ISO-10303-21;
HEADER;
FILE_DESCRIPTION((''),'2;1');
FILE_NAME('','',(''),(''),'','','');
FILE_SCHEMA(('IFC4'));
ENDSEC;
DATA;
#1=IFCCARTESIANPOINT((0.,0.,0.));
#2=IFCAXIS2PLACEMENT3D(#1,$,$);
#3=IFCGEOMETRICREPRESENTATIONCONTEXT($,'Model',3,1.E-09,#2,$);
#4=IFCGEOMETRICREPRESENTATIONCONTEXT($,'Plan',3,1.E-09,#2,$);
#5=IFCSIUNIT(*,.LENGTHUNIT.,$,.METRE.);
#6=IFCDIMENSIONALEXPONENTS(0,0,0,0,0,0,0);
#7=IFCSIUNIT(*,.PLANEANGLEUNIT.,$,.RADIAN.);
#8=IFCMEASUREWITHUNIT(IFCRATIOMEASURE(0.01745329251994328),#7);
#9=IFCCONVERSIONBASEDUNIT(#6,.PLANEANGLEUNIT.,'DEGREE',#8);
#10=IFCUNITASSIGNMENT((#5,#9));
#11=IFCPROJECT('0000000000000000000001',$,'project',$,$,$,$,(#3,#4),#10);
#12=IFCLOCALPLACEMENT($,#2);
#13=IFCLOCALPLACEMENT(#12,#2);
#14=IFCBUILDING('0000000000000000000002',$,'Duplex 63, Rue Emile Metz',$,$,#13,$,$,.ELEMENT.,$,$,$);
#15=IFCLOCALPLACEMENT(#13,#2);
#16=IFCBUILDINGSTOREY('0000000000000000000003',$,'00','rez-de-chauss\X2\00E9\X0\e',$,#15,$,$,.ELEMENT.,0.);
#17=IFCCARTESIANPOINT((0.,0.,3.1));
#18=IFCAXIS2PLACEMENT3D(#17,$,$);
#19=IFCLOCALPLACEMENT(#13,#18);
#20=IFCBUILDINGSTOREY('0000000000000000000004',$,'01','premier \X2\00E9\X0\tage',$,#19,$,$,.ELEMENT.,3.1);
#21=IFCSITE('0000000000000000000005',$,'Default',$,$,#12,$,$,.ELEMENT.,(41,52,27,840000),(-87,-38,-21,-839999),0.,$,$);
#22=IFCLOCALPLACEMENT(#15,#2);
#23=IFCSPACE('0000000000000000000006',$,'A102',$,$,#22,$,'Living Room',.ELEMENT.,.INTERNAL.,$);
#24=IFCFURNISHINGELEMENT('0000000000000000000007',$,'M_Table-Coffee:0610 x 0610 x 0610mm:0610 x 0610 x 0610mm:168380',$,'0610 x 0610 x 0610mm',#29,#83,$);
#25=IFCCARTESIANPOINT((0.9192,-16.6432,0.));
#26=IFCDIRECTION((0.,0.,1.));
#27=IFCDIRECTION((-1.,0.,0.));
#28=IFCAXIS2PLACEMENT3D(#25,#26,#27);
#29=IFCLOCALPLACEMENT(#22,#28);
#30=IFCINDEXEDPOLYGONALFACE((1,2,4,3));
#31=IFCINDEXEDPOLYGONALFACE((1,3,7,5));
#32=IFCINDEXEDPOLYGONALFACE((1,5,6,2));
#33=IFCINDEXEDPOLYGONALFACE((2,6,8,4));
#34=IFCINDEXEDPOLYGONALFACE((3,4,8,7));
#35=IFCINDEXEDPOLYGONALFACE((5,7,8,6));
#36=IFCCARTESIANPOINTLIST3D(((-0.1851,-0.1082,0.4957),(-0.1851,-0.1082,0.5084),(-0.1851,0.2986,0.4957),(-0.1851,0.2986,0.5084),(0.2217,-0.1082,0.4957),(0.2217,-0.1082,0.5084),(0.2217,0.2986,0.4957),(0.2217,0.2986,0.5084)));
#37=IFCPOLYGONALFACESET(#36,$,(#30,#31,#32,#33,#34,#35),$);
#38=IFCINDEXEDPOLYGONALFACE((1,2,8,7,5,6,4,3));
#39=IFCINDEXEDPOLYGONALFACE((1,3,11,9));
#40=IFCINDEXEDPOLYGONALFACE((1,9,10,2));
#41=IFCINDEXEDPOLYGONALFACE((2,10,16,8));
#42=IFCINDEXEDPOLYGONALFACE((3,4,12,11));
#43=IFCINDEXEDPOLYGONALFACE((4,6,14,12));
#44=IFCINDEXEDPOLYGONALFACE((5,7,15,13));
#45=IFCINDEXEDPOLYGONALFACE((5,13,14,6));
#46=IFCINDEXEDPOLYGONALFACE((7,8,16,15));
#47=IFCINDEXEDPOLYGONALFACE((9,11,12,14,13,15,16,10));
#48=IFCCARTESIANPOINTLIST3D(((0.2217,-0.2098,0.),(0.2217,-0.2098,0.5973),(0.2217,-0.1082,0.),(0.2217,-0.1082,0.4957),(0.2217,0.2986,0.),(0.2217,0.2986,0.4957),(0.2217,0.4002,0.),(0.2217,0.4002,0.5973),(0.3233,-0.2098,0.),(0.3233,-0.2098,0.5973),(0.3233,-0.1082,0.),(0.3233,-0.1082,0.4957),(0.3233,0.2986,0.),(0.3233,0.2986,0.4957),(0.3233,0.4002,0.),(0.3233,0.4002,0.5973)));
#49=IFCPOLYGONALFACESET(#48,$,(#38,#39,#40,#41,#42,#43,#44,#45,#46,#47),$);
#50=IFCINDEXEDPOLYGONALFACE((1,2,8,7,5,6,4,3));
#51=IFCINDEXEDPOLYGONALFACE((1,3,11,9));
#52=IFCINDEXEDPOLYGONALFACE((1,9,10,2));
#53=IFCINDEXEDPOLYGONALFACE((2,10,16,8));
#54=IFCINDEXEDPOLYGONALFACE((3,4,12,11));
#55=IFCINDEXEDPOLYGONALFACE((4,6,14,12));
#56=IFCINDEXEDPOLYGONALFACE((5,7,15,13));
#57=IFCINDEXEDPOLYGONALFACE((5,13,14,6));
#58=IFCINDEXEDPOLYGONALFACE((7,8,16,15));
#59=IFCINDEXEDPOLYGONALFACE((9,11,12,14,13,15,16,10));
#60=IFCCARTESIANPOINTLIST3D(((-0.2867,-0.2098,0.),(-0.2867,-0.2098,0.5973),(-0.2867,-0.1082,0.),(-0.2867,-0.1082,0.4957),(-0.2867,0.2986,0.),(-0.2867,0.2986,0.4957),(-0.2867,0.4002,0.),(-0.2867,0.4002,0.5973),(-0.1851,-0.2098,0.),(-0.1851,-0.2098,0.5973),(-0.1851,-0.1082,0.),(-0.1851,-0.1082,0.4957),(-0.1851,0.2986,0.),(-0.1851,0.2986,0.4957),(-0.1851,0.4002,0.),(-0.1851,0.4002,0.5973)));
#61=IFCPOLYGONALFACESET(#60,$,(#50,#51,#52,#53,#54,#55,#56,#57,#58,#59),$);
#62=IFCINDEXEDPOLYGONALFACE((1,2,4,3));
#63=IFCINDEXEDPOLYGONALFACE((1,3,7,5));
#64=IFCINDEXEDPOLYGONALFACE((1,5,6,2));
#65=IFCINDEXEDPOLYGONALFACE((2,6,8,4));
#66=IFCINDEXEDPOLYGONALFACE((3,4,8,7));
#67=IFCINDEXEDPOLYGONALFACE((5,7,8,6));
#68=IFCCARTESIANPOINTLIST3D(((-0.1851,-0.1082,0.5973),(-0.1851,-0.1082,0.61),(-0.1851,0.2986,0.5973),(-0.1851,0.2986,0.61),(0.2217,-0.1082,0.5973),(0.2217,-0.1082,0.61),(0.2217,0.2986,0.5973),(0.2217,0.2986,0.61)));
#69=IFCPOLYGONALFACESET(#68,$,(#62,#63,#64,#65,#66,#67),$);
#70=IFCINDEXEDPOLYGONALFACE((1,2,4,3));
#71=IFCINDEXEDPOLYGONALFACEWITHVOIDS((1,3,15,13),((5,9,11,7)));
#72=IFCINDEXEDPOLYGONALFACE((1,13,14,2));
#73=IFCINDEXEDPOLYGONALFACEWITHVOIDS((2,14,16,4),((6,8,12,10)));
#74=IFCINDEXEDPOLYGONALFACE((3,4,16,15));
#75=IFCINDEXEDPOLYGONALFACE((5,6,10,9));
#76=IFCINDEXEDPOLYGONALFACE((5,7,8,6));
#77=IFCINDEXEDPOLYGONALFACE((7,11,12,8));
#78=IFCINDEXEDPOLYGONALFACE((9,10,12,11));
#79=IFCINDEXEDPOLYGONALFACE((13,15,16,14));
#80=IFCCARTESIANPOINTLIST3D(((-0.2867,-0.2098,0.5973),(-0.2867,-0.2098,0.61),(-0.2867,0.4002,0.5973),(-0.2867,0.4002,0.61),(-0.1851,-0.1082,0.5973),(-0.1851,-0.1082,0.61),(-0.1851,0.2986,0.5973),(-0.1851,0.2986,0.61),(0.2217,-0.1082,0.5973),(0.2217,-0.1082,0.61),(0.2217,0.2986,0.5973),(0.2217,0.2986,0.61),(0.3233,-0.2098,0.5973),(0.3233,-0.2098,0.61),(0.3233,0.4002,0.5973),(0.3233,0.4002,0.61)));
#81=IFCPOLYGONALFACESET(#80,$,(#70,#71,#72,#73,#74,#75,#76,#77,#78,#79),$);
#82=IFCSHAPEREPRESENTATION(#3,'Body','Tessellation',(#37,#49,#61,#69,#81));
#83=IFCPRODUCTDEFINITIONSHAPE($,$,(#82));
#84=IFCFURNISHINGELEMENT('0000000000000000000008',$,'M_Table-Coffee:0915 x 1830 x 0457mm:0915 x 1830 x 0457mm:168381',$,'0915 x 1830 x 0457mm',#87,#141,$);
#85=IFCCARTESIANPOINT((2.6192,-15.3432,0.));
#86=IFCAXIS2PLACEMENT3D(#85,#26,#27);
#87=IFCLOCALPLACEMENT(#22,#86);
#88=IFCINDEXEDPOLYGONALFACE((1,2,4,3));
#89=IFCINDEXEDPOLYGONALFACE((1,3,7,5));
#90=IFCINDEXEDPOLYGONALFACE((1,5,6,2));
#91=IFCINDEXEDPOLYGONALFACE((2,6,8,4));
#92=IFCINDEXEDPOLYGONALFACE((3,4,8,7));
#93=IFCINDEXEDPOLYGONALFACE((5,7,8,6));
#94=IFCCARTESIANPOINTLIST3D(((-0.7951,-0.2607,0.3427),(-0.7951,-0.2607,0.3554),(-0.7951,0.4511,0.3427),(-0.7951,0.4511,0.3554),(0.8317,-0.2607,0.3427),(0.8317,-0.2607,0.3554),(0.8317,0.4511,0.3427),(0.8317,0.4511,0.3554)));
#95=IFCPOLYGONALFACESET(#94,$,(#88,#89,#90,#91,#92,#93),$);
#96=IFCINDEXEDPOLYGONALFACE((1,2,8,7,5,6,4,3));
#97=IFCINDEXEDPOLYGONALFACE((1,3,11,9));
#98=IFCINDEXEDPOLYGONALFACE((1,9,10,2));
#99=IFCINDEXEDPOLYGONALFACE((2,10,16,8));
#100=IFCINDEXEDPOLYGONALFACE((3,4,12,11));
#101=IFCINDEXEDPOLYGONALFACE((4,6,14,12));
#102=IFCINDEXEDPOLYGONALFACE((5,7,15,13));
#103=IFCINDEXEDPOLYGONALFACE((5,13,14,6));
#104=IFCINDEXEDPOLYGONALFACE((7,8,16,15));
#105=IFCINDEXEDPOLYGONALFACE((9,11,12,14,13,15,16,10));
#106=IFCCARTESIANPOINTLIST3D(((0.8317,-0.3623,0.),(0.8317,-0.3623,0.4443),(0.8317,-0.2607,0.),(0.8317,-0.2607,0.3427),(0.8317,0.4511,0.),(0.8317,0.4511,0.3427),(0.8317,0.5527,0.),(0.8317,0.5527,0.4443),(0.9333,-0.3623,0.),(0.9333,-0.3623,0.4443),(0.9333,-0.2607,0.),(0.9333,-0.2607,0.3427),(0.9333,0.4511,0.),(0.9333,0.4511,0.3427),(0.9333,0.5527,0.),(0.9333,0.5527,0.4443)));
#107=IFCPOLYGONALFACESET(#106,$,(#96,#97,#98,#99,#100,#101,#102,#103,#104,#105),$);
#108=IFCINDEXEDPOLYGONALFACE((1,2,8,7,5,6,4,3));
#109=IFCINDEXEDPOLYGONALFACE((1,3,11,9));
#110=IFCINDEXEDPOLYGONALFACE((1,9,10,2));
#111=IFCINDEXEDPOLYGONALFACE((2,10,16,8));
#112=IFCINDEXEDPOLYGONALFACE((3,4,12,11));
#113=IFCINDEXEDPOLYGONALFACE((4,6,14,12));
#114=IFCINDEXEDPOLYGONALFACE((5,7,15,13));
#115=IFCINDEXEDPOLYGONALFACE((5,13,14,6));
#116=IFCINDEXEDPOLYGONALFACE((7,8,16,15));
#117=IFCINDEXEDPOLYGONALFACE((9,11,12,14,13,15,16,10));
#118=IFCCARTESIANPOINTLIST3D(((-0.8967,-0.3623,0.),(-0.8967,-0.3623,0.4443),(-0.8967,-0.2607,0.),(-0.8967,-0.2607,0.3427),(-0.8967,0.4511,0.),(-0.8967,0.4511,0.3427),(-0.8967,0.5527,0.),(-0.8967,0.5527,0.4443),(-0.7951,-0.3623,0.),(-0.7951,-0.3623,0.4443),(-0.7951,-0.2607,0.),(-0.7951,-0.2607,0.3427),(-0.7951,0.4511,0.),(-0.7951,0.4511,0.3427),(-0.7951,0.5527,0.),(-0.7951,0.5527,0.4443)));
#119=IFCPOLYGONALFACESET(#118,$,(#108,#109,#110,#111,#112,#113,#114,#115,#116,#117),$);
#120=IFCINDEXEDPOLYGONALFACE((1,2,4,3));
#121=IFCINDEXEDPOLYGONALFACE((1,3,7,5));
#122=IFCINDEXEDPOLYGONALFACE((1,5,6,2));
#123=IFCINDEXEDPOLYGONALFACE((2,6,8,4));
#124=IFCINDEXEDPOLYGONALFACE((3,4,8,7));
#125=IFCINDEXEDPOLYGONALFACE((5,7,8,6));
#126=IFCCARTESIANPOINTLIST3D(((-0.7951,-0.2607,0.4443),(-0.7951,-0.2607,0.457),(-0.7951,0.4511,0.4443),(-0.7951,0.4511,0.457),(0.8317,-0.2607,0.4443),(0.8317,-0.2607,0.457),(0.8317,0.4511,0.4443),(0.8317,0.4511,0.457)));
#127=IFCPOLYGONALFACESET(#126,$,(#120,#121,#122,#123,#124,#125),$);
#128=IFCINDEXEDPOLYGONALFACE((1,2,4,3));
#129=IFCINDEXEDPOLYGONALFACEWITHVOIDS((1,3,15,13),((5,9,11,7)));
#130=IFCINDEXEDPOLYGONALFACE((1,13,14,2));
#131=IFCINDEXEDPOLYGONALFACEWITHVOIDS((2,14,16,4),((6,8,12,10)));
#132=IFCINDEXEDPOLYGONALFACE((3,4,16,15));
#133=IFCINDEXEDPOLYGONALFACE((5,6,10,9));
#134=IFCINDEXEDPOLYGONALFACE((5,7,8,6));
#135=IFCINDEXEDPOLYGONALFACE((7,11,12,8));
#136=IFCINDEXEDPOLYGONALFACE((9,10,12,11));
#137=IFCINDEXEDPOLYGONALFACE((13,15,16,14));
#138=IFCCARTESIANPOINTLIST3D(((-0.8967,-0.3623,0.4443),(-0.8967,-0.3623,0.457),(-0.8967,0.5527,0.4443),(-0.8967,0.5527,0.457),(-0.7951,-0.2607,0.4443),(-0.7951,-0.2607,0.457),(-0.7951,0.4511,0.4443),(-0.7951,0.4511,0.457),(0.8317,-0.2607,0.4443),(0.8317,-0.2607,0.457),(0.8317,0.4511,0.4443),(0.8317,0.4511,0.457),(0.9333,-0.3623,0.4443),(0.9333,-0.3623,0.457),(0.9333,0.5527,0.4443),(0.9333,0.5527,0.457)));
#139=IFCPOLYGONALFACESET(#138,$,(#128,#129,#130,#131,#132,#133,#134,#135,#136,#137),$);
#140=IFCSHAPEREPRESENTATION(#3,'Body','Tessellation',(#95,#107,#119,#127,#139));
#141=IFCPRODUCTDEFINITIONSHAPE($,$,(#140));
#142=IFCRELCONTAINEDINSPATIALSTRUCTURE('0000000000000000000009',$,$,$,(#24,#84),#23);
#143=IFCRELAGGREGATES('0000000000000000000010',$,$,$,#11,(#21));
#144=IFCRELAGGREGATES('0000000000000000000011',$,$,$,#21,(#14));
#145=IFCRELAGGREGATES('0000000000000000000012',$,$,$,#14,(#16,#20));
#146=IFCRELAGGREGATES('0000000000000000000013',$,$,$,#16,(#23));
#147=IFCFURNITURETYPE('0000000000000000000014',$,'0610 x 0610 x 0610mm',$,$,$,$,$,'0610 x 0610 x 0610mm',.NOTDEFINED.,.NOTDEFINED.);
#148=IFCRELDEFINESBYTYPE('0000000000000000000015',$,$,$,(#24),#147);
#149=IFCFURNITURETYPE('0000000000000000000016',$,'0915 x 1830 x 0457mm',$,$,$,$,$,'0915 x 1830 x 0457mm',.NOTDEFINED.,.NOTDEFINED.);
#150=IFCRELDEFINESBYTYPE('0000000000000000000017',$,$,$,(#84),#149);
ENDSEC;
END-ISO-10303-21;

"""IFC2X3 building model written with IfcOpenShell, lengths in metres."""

from ifc_helpers import new_model, entity, si_unit, converted_unit, frame, origin, origin_2d_with_axis, place, context, project, spatial, polyline, rectangle, outline, extrude, source, transform, mapped, type_object, type_shapes, element, save


model = new_model("IFC2X3")

# Units and contexts
model_context = context("Model", 3, precision=1e-09, world=origin())
plan_context = context("Plan", 3, precision=1e-09, world=origin())
ifc_project = project(units=[si_unit("LENGTHUNIT", "METRE"), converted_unit("PLANEANGLEUNIT", "DEGREE", entity("IfcRatioMeasure", 0.01745329251994328), si_unit("PLANEANGLEUNIT", "RADIAN"), dimensions=[0, 0, 0, 0, 0, 0, 0])], contexts=[model_context, plan_context])

# Site, building, storey
site_placement = place(None, origin())
site = spatial("IfcSite", under=ifc_project, at=site_placement, Name="Default", CompositionType="ELEMENT", RefLatitude=(41, 52, 27, 840000), RefLongitude=(-87, -38, -21, -839999), RefElevation=0.0)
building_placement = place(site_placement, origin())
building = spatial("IfcBuilding", under=site, at=building_placement, Name="Duplex 63, Rue Emile Metz", CompositionType="ELEMENT")
storey_1_placement = place(building_placement, origin())
storey_1 = spatial("IfcBuildingStorey", under=building, at=storey_1_placement, Name="00", Description="rez-de-chaussée", CompositionType="ELEMENT", Elevation=0.0)

# Shared definitions
storey_2_placement = place(building_placement, frame((0.0, 0.0, 3.1)))
storey_2 = spatial("IfcBuildingStorey", under=building, at=storey_2_placement, Name="01", Description="premier étage", CompositionType="ELEMENT", Elevation=3.1)

# Shared definitions
space_1_placement = place(storey_1_placement, origin())
space_1 = spatial("IfcSpace", under=storey_1, at=space_1_placement, Name="A102", LongName="Living Room", CompositionType="ELEMENT", InteriorOrExteriorSpace="INTERNAL")

# Furnishing element
furniture_type_1 = type_object("IfcFurnitureType", Name="0610 x 0610 x 0610mm", ElementType="0610 x 0610 x 0610mm", AssemblyPlace="NOTDEFINED")
shared_shape_1 = source(origin(), model_context, "Body", "SweptSolid", [
    extrude(rectangle(XDim=0.4068, YDim=0.4068, at=origin_2d_with_axis()), frame((0.0183, 0.0952, 0.4957), z_axis=(0.0, 0.0, 1.0), x_axis=(-1.0, 0.0, 0.0)), (0.0, 0.0, 1.0), 0.0127),
    extrude(outline(polyline([(-0.2732, -0.305), (0.324, -0.305), (0.324, 0.305), (-0.2732, 0.305), (-0.2732, 0.2034), (0.2225, 0.2034), (0.2225, -0.2034), (-0.2732, -0.2034), (-0.2732, -0.305)])), frame((0.2217, 0.0952, 0.2732), z_axis=(1.0, 0.0, 0.0), x_axis=(0.0, 0.0, 1.0)), (0.0, 0.0, 1.0), 0.1016),
    extrude(outline(polyline([(-0.305, -0.3241), (0.305, -0.3241), (0.305, 0.2733), (0.2034, 0.2733), (0.2034, -0.2224), (-0.2034, -0.2224), (-0.2034, 0.2733), (-0.305, 0.2733), (-0.305, -0.3241)])), frame((-0.2867, 0.0952, 0.2733), z_axis=(1.0, 0.0, 0.0), x_axis=(0.0, -1.0, 0.0)), (0.0, 0.0, 1.0), 0.1016),
    extrude(rectangle(XDim=0.4068, YDim=0.4068, at=origin_2d_with_axis()), frame((0.0183, 0.0952, 0.5973), z_axis=(0.0, 0.0, 1.0), x_axis=(-1.0, 0.0, 0.0)), (0.0, 0.0, 1.0), 0.0127),
    extrude(outline(polyline([(-0.305, -0.305), (0.305, -0.305), (0.305, 0.305), (-0.305, 0.305), (-0.305, -0.305)]), holes=[polyline([(-0.2034, -0.2034), (-0.2034, 0.2034), (0.2034, 0.2034), (0.2034, -0.2034), (-0.2034, -0.2034)])]), frame((0.0183, 0.0952, 0.5973), z_axis=(0.0, 0.0, 1.0), x_axis=(-1.0, 0.0, 0.0)), (0.0, 0.0, 1.0), 0.0127),
])
type_shapes(furniture_type_1, [shared_shape_1])
for number, where, z_axis, x_axis, name in (
    (1, (0.9192, -16.6432, 0.0), (0.0, 0.0, 1.0), (-1.0, 0.0, 0.0), "M_Table-Coffee:0610 x 0610 x 0610mm:0610 x 0610 x 0610mm:168380"),
):
    element("IfcFurnishingElement", number, at=place(space_1_placement, frame(where, z_axis=z_axis, x_axis=x_axis)), inside=space_1, type_object=furniture_type_1, Name=name, ObjectType="0610 x 0610 x 0610mm", context=model_context, shape_type="MappedRepresentation", body=[
        mapped(shared_shape_1, transform((0.0, 0.0, 0.0), scale=1.0)),
    ])

# Furnishing element
furniture_type_2 = type_object("IfcFurnitureType", Name="0915 x 1830 x 0457mm", ElementType="0915 x 1830 x 0457mm", AssemblyPlace="NOTDEFINED")
shared_shape_2 = source(origin(), model_context, "Body", "SweptSolid", [
    extrude(rectangle(XDim=1.6268, YDim=0.7118, at=origin_2d_with_axis()), frame((0.0183, 0.0952, 0.3427), z_axis=(0.0, 0.0, 1.0), x_axis=(-1.0, 0.0, 0.0)), (0.0, 0.0, 1.0), 0.0127),
    extrude(outline(polyline([(-0.1967, -0.4575), (0.2475, -0.4575), (0.2475, 0.4575), (-0.1967, 0.4575), (-0.1967, 0.3559), (0.146, 0.3559), (0.146, -0.3559), (-0.1967, -0.3559), (-0.1967, -0.4575)])), frame((0.8317, 0.0952, 0.1967), z_axis=(1.0, 0.0, 0.0), x_axis=(0.0, 0.0, 1.0)), (0.0, 0.0, 1.0), 0.1016),
    extrude(outline(polyline([(-0.4575, -0.2476), (0.4575, -0.2476), (0.4575, 0.1968), (0.3559, 0.1968), (0.3559, -0.1459), (-0.3559, -0.1459), (-0.3559, 0.1968), (-0.4575, 0.1968), (-0.4575, -0.2476)])), frame((-0.8967, 0.0952, 0.1968), z_axis=(1.0, 0.0, 0.0), x_axis=(0.0, -1.0, 0.0)), (0.0, 0.0, 1.0), 0.1016),
    extrude(rectangle(XDim=1.6268, YDim=0.7118, at=origin_2d_with_axis()), frame((0.0183, 0.0952, 0.4443), z_axis=(0.0, 0.0, 1.0), x_axis=(-1.0, 0.0, 0.0)), (0.0, 0.0, 1.0), 0.0127),
    extrude(outline(polyline([(-0.915, -0.4575), (0.915, -0.4575), (0.915, 0.4575), (-0.915, 0.4575), (-0.915, -0.4575)]), holes=[polyline([(-0.8134, -0.3559), (-0.8134, 0.3559), (0.8134, 0.3559), (0.8134, -0.3559), (-0.8134, -0.3559)])]), frame((0.0183, 0.0952, 0.4443), z_axis=(0.0, 0.0, 1.0), x_axis=(-1.0, 0.0, 0.0)), (0.0, 0.0, 1.0), 0.0127),
])
type_shapes(furniture_type_2, [shared_shape_2])
furnishing_1_placement = place(space_1_placement, frame((2.6192, -15.3432, 0.0), z_axis=(0.0, 0.0, 1.0), x_axis=(-1.0, 0.0, 0.0)))
element("IfcFurnishingElement", 2, at=furnishing_1_placement, inside=space_1, type_object=furniture_type_2, Name="M_Table-Coffee:0915 x 1830 x 0457mm:0915 x 1830 x 0457mm:168381", ObjectType="0915 x 1830 x 0457mm", context=model_context, shape_type="MappedRepresentation", body=[
    mapped(shared_shape_2, transform((0.0, 0.0, 0.0), scale=1.0)),
])

save(model, "model.ifc")
